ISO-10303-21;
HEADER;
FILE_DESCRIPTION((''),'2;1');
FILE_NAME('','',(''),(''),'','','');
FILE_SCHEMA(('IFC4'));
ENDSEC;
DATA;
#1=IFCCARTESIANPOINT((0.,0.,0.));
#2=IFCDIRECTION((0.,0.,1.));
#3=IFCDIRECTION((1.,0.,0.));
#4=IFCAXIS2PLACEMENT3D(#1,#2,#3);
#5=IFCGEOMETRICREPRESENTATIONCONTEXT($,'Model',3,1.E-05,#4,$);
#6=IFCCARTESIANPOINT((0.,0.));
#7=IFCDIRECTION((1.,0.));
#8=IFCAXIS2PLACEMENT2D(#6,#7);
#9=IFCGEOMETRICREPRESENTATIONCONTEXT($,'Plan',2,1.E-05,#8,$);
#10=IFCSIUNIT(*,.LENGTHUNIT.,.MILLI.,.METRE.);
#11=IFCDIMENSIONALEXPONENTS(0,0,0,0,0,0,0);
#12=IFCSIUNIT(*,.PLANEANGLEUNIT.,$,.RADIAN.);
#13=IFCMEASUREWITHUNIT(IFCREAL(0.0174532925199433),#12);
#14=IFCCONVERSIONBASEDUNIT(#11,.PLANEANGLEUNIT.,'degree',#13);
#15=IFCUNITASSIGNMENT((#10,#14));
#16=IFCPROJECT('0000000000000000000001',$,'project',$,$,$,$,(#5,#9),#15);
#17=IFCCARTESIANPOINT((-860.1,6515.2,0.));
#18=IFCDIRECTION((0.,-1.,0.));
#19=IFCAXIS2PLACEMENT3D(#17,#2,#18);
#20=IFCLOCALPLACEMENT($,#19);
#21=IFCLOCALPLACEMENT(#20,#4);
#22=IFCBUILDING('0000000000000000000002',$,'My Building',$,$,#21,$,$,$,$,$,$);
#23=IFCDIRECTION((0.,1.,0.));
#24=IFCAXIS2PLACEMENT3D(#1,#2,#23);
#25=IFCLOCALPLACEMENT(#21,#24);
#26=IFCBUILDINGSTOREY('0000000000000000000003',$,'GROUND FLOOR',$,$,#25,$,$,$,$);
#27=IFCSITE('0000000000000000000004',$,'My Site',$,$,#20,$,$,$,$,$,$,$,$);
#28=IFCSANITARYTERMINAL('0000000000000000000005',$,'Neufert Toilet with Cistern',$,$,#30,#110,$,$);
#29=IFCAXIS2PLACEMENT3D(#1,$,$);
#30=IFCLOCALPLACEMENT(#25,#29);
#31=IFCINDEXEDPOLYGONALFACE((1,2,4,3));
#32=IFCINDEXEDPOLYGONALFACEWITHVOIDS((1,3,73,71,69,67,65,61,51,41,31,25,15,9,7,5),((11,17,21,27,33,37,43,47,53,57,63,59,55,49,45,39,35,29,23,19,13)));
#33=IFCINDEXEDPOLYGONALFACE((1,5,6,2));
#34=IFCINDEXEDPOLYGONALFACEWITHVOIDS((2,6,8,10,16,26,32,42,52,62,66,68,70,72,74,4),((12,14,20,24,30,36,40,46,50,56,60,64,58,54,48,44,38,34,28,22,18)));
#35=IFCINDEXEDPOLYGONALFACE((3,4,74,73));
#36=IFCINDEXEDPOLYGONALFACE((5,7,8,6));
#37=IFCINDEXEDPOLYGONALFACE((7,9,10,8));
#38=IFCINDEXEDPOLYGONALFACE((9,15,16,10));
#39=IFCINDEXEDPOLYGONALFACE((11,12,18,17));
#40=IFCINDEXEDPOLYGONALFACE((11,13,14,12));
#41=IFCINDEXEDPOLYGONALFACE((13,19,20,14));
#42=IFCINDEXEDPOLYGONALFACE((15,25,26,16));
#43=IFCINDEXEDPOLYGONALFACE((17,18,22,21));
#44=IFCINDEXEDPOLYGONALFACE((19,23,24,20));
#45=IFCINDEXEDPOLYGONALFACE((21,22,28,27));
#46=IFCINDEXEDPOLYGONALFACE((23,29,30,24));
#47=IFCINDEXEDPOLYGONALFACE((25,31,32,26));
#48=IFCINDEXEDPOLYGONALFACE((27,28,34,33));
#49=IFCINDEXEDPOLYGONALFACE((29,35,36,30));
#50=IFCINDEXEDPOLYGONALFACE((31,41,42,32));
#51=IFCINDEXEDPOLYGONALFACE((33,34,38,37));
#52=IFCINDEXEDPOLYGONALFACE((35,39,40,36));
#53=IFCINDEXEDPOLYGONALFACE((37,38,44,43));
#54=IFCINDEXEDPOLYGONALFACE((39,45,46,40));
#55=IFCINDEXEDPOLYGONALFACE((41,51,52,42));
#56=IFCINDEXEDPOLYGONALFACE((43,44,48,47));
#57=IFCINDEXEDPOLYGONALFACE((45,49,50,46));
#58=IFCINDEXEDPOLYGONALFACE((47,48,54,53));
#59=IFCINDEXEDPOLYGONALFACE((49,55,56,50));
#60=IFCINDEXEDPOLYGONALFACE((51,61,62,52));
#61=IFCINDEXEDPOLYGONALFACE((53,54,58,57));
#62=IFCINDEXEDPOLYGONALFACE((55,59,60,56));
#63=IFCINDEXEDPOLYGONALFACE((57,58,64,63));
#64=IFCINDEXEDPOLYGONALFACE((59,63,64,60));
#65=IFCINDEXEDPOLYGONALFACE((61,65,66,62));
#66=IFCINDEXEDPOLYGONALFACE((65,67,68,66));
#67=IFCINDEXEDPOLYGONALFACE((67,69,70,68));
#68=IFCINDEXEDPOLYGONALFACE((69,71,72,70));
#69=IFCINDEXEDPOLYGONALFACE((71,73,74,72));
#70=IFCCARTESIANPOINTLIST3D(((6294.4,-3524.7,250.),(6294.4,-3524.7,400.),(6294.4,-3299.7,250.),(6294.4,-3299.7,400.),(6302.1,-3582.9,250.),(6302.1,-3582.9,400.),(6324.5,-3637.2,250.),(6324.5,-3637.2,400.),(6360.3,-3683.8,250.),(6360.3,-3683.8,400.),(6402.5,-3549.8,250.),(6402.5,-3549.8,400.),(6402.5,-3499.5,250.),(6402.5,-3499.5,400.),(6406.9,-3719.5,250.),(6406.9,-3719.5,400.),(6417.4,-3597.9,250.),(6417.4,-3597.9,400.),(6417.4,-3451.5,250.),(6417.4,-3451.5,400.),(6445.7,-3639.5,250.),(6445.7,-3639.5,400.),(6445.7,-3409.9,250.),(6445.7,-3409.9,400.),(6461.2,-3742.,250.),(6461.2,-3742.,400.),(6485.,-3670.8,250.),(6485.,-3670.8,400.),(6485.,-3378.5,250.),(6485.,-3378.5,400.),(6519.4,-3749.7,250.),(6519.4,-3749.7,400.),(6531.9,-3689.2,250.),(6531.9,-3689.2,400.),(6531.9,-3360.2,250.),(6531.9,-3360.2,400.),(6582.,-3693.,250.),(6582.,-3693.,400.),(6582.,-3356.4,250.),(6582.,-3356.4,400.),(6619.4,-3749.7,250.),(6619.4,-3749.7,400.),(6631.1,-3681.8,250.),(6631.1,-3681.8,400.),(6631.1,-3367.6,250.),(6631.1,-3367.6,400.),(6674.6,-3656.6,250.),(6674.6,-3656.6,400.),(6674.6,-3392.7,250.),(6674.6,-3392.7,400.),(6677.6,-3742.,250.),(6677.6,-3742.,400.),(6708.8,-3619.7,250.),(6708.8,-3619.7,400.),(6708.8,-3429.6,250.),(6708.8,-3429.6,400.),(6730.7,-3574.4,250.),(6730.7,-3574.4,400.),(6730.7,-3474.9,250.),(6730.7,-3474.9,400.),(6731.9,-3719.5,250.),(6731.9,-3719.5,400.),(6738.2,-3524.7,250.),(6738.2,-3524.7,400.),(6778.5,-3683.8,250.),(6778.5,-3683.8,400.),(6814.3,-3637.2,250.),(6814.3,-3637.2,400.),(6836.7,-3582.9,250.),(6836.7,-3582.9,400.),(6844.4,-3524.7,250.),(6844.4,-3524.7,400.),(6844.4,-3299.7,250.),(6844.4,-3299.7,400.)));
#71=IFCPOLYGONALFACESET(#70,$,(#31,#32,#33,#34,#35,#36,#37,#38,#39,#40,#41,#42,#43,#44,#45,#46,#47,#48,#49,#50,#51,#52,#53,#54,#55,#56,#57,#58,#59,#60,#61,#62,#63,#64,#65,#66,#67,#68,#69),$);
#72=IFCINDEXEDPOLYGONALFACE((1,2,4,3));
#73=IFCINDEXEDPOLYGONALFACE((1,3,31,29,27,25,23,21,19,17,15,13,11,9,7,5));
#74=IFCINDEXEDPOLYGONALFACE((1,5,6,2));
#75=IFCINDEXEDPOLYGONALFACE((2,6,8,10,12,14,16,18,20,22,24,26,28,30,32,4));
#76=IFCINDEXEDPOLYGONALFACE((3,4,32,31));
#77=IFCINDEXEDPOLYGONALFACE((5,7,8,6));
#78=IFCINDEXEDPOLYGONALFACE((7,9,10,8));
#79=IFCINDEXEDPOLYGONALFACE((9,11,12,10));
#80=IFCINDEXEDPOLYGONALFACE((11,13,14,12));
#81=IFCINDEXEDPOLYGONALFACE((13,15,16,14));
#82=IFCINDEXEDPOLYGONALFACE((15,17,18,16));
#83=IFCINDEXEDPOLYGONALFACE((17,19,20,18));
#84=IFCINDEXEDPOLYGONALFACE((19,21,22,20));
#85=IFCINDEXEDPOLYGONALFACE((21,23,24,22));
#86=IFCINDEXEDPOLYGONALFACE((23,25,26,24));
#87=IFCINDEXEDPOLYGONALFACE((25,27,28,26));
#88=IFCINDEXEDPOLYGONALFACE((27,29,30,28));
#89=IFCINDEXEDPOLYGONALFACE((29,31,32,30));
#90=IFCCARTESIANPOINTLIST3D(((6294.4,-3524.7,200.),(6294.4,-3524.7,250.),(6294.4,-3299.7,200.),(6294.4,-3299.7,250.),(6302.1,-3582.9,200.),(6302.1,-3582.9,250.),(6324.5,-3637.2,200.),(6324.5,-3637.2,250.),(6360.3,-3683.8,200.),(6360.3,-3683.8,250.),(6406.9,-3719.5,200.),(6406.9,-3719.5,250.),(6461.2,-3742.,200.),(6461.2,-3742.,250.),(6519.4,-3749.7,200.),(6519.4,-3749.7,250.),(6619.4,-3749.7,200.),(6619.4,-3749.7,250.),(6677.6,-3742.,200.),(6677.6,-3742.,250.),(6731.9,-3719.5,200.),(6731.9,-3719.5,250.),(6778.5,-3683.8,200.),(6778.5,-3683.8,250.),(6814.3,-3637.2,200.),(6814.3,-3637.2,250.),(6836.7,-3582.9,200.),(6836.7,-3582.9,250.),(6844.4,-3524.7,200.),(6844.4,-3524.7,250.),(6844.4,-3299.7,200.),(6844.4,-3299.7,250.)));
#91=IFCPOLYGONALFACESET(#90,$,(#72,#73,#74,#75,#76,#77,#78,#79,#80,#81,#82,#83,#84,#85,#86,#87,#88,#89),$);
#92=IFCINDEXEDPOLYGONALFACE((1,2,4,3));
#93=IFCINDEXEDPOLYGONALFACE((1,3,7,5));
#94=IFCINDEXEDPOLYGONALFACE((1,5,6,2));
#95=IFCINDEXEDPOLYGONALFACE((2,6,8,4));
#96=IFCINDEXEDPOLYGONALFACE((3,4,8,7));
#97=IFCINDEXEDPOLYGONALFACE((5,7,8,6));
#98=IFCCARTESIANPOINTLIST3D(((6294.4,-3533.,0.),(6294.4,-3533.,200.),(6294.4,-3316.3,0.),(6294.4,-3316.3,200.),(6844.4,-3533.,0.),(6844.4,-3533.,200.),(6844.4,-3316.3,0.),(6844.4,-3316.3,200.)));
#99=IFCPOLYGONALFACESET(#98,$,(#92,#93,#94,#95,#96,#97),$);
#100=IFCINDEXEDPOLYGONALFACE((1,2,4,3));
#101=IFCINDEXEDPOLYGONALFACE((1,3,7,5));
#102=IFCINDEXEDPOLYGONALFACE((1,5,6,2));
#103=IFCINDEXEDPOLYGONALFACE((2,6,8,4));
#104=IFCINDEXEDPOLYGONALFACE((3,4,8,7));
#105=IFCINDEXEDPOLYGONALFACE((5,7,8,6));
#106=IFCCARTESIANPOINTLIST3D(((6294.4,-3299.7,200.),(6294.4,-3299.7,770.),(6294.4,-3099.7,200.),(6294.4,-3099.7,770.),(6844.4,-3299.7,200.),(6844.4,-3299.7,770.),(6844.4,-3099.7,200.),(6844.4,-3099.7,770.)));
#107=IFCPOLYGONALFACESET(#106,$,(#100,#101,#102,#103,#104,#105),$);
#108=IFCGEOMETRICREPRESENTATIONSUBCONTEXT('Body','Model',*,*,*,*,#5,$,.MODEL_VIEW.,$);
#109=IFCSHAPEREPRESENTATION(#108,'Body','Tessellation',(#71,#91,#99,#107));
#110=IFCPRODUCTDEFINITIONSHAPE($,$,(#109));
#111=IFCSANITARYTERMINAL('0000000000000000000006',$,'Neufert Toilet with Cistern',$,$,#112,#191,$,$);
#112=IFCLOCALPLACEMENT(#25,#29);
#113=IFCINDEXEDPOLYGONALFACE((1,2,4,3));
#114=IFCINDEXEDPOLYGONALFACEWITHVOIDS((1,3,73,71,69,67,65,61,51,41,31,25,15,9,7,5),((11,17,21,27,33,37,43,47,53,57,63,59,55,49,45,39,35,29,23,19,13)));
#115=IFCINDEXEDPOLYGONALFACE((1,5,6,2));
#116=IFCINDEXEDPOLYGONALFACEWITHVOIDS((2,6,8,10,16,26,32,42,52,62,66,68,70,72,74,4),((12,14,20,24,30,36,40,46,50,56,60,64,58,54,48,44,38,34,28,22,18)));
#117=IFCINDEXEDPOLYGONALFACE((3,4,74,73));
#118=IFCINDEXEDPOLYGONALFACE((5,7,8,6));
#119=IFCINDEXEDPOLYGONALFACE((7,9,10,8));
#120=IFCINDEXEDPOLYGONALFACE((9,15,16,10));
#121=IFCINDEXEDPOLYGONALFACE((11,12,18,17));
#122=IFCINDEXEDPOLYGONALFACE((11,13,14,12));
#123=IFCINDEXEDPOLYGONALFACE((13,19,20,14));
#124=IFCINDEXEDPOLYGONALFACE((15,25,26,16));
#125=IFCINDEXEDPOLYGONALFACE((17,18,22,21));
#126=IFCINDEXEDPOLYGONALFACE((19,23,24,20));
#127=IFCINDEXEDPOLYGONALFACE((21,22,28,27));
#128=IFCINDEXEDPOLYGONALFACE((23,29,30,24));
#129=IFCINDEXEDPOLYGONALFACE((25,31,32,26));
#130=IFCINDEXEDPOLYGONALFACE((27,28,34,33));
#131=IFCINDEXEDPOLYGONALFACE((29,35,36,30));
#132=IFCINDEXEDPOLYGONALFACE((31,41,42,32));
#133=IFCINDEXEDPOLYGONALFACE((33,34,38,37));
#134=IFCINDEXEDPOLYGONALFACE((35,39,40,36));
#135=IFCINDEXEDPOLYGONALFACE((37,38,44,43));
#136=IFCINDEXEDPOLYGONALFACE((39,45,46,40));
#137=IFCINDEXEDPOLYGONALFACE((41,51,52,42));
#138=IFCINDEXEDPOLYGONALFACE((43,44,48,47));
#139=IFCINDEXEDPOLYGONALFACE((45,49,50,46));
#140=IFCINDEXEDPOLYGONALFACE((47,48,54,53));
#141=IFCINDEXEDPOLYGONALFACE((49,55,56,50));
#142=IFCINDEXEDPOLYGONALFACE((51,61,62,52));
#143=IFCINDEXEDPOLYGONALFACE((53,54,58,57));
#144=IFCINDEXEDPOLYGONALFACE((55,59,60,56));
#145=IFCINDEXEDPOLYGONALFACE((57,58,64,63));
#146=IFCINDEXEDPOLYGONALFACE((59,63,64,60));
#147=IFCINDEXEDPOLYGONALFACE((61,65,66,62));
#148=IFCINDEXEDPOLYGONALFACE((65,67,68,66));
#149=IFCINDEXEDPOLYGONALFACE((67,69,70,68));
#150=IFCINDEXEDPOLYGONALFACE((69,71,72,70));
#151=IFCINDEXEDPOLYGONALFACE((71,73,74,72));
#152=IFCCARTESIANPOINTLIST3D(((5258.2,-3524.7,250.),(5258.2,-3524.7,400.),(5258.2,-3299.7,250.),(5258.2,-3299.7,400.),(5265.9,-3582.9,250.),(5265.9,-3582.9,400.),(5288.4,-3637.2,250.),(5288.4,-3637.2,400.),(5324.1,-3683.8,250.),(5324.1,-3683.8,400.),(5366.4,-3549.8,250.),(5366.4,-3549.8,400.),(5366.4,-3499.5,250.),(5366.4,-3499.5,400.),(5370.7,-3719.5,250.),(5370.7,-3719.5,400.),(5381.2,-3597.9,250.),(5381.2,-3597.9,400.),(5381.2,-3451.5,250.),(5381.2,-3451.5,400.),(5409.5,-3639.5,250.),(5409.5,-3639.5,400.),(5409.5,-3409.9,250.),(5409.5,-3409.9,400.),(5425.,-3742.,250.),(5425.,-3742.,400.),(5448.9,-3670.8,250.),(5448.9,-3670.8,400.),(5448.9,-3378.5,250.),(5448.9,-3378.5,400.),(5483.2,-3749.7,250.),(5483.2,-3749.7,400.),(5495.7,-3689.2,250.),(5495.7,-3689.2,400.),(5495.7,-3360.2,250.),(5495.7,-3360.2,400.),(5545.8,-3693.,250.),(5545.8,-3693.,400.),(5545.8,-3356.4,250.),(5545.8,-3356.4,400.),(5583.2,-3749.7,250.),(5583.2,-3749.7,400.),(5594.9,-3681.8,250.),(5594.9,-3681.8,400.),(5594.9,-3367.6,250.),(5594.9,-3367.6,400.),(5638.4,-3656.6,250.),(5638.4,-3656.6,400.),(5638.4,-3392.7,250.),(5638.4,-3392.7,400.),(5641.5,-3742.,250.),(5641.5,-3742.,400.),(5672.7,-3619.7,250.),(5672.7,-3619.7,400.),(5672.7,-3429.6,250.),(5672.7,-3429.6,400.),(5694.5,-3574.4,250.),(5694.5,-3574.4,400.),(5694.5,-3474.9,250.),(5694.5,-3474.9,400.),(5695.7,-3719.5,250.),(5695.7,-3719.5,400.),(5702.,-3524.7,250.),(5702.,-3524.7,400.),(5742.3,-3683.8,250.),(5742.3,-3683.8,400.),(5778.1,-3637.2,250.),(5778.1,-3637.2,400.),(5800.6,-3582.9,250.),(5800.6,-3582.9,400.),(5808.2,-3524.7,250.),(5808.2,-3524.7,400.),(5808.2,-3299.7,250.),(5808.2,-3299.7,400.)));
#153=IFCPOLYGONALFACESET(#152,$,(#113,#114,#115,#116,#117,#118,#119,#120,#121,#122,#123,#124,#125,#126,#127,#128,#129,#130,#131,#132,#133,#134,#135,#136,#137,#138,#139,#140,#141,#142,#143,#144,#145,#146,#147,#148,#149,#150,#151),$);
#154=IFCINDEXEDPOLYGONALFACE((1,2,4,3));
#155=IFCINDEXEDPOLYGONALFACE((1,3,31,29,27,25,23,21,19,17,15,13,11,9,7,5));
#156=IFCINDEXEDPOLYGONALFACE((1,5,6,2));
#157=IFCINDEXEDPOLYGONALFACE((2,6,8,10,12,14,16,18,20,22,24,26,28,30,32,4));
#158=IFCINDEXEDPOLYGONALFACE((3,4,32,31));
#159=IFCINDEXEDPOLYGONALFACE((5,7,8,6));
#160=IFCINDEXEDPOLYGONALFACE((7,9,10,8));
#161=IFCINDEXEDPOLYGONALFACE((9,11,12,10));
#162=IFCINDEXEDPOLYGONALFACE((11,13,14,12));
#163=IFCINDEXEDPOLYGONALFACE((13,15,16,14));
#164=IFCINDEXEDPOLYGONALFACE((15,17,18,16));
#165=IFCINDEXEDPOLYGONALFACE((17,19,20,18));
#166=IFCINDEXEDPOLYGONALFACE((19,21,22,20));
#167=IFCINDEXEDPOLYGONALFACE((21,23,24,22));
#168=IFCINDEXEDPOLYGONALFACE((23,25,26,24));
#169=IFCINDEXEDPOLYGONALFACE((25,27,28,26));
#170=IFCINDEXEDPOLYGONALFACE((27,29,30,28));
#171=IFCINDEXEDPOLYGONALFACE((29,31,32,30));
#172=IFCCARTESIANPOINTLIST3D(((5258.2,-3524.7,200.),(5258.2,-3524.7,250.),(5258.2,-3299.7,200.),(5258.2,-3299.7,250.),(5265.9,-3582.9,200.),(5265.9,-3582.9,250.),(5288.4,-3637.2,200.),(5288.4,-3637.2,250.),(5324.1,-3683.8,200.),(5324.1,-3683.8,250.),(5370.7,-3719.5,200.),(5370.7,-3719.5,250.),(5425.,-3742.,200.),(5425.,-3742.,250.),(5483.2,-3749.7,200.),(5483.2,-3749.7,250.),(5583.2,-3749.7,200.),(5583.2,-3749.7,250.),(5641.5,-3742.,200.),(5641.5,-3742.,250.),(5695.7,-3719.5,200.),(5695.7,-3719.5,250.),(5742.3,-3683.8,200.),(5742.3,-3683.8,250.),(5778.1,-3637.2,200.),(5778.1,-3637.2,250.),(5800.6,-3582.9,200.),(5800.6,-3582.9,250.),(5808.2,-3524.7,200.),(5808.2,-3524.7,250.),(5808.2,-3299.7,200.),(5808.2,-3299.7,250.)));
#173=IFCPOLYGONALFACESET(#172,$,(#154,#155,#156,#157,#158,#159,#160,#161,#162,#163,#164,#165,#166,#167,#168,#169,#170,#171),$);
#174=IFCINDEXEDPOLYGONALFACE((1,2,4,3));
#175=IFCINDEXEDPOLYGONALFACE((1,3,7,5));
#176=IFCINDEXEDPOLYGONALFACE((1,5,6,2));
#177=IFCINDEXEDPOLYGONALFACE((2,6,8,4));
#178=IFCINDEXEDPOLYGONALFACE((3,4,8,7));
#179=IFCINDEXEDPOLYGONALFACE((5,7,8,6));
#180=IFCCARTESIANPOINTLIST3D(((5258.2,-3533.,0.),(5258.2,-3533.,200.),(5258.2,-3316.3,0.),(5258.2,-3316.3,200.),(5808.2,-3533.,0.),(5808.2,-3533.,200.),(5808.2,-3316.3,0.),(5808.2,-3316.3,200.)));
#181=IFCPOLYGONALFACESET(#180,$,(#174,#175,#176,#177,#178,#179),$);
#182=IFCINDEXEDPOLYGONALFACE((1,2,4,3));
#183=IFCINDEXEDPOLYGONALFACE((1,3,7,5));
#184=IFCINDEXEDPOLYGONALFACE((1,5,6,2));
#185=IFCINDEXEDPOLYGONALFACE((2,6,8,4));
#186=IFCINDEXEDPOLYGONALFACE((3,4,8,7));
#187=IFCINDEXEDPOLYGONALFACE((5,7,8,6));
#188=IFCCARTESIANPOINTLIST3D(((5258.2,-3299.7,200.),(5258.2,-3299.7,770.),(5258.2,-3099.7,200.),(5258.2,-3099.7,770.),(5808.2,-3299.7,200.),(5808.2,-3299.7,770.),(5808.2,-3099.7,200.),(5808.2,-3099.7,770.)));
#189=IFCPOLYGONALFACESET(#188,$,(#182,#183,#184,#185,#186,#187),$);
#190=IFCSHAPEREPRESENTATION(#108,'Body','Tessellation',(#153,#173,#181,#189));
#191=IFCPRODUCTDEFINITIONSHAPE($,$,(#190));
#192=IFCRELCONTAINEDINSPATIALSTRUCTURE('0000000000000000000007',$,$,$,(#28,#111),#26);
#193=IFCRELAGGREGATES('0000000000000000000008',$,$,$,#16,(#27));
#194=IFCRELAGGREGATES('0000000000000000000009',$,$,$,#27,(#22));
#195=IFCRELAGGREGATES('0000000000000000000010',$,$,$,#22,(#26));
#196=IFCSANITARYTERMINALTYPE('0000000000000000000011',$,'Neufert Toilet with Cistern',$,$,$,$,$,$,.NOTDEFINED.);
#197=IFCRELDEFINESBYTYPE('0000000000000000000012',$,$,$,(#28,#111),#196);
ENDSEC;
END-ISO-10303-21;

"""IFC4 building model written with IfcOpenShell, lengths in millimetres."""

from ifc_helpers import new_model, entity, si_unit, converted_unit, frame, frame_2d, origin_with_axes, origin_2d_with_axis, place, context, subcontext, project, spatial, line, arc, indexed_curve, circle_curve, outline, extrude, shape, source, transform, mapped, type_object, type_shapes, element, save


model = new_model("IFC4")

# Units and contexts
model_context = context("Model", 3, precision=1e-05, world=origin_with_axes())
plan_context = context("Plan", 2, precision=1e-05, world=origin_2d_with_axis())
body_context_1 = subcontext(model_context, "Body", "Model", "MODEL_VIEW")
body_context_2 = subcontext(plan_context, "Body", "Plan", "PLAN_VIEW")
ifc_project = project(units=[si_unit("LENGTHUNIT", "METRE", prefix="MILLI"), converted_unit("PLANEANGLEUNIT", "degree", entity("IfcReal", 0.0174532925199433), si_unit("PLANEANGLEUNIT", "RADIAN"), dimensions=[0, 0, 0, 0, 0, 0, 0])], contexts=[model_context, plan_context])

# Site, building, storey
site_placement = place(None, frame((-860.1, 6515.2, 0.0), z_axis=(0.0, 0.0, 1.0), x_axis=(0.0, -1.0, 0.0)))
site = spatial("IfcSite", under=ifc_project, at=site_placement, Name="My Site")
building_placement = place(site_placement, frame((0.0, 0.0, 0.0), z_axis=(0.0, 0.0, 1.0), x_axis=(1.0, 0.0, 0.0)))
building = spatial("IfcBuilding", under=site, at=building_placement, Name="My Building")
storey_placement = place(building_placement, frame((0.0, 0.0, 0.0), z_axis=(0.0, 0.0, 1.0), x_axis=(0.0, 1.0, 0.0)))
storey = spatial("IfcBuildingStorey", under=building, at=storey_placement, Name="GROUND FLOOR")

# Sanitary terminals
sanitary_terminal_type_1 = type_object("IfcSanitaryTerminalType", Name="Neufert Toilet with Cistern", PredefinedType="NOTDEFINED")
shared_shape_1 = source(origin_with_axes(), body_context_1, "Body", "SweptSolid", [
    extrude(outline(indexed_curve([(-275.0, -200.0), (275.0, -200.0), (275.0, -425.0), (209.1, -584.1), (50.0, -650.0), (-50.0, -650.0), (-209.1, -584.1), (-275.0, -425.0)], segments=[line(1, 2), line(2, 3), arc(3, 4, 5), line(5, 6), arc(6, 7, 8), line(8, 1)]), holes=[circle_curve(frame_2d((0.0, -425.0)), 168.8)]), frame((0.0, 0.0, 250.0), z_axis=(0.0, 0.0, 1.0), x_axis=(1.0, 0.0, 0.0)), (0.0, 0.0, 1.0), 150.0),
    extrude(outline(indexed_curve([(-275.0, -200.0), (275.0, -200.0), (275.0, -425.0), (209.1, -584.1), (50.0, -650.0), (-50.0, -650.0), (-209.1, -584.1), (-275.0, -425.0)], segments=[line(1, 2), line(2, 3), arc(3, 4, 5), line(5, 6), arc(6, 7, 8), line(8, 1)])), frame((0.0, 0.0, 200.0), z_axis=(0.0, 0.0, 1.0), x_axis=(1.0, 0.0, 0.0)), (0.0, 0.0, 1.0), 50.0),
    extrude(outline(indexed_curve([(-275.0, -216.7), (275.0, -216.7), (275.0, -433.3), (-275.0, -433.3)], segments=[line(1, 2), line(2, 3), line(3, 4), line(4, 1)])), origin_with_axes(), (0.0, 0.0, 1.0), 200.0),
    extrude(outline(indexed_curve([(-275.0, 0.0), (275.0, 0.0), (275.0, -200.0), (-275.0, -200.0)], segments=[line(1, 2), line(2, 3), line(3, 4), line(4, 1)])), frame((0.0, 0.0, 200.0), z_axis=(0.0, 0.0, 1.0), x_axis=(1.0, 0.0, 0.0)), (0.0, 0.0, 1.0), 570.0),
])
shared_shape_2 = source(origin_with_axes(), body_context_2, "Body", "Curve2D", [
    entity("IfcIndexedPolyCurve", entity("IfcCartesianPointList2D", [[-275.0, 0.0], [275.0, 0.0], [275.0, -200.0], [-275.0, -200.0]]), [entity("IfcLineIndex", [1, 2]), entity("IfcLineIndex", [2, 3]), entity("IfcLineIndex", [3, 4]), entity("IfcLineIndex", [4, 1])]),
    entity("IfcIndexedPolyCurve", entity("IfcCartesianPointList2D", [[165.0, -200.0], [192.5, -335.0]]), [entity("IfcLineIndex", [1, 2])]),
    entity("IfcTrimmedCurve", entity("IfcEllipse", entity("IfcAxis2Placement2D", entity("IfcCartesianPoint", [0.0, -335.0]), entity("IfcDirection", [1.0, 0.0])), 192.5, 315.0), [entity("IfcCartesianPoint", [-192.5, -335.0])], [entity("IfcCartesianPoint", [192.5, -335.0])], True, "CARTESIAN"),
    entity("IfcIndexedPolyCurve", entity("IfcCartesianPointList2D", [[-165.0, -200.0], [-192.5, -335.0]]), [entity("IfcLineIndex", [1, 2])]),
    entity("IfcEllipse", entity("IfcAxis2Placement2D", entity("IfcCartesianPoint", [0.0, -452.0]), entity("IfcDirection", [1.0, 0.0])), 131.2, 157.5),
    entity("IfcIndexedPolyCurve", entity("IfcCartesianPointList2D", [[-34.4, -452.0], [-34.4, -429.5], [34.4, -429.5], [34.4, -452.0]]), [entity("IfcLineIndex", [1, 2]), entity("IfcLineIndex", [2, 3]), entity("IfcLineIndex", [3, 4])]),
    entity("IfcTrimmedCurve", entity("IfcEllipse", entity("IfcAxis2Placement2D", entity("IfcCartesianPoint", [0.0, -452.0]), entity("IfcDirection", [1.0, 0.0])), 34.4, 22.5), [entity("IfcCartesianPoint", [-34.4, -452.0])], [entity("IfcCartesianPoint", [34.4, -452.0])], True, "CARTESIAN"),
])
type_shapes(sanitary_terminal_type_1, [shared_shape_1, shared_shape_2])
for number, where, z_axis, x_axis, name in (
    (1, (6569.4, -3099.7, 0.0), (0.0, 0.0, 1.0), (1.0, 0.0, 0.0), "Neufert Toilet with Cistern"),
    (2, (5533.2, -3099.7, 0.0), (0.0, 0.0, 1.0), (1.0, 0.0, 0.0), "Neufert Toilet with Cistern"),
):
    element("IfcSanitaryTerminal", number, at=place(storey_placement, frame(where, z_axis=z_axis, x_axis=x_axis)), inside=storey, type_object=sanitary_terminal_type_1, Name=name, shapes=[
        shape(body_context_1, "Body", "MappedRepresentation", [mapped(shared_shape_1, transform((0.0, 0.0, 0.0), x_axis=(1.0, 0.0, 0.0), y_axis=(0.0, 1.0, 0.0), z_axis=(0.0, 0.0, 1.0), scale=1.0))]),
        shape(body_context_2, "Body", "MappedRepresentation", [mapped(shared_shape_2, transform((0.0, 0.0, 0.0), x_axis=(1.0, 0.0, 0.0), y_axis=(0.0, 1.0, 0.0), z_axis=(0.0, 0.0, 1.0), scale=1.0))]),
    ])

save(model, "model.ifc")
